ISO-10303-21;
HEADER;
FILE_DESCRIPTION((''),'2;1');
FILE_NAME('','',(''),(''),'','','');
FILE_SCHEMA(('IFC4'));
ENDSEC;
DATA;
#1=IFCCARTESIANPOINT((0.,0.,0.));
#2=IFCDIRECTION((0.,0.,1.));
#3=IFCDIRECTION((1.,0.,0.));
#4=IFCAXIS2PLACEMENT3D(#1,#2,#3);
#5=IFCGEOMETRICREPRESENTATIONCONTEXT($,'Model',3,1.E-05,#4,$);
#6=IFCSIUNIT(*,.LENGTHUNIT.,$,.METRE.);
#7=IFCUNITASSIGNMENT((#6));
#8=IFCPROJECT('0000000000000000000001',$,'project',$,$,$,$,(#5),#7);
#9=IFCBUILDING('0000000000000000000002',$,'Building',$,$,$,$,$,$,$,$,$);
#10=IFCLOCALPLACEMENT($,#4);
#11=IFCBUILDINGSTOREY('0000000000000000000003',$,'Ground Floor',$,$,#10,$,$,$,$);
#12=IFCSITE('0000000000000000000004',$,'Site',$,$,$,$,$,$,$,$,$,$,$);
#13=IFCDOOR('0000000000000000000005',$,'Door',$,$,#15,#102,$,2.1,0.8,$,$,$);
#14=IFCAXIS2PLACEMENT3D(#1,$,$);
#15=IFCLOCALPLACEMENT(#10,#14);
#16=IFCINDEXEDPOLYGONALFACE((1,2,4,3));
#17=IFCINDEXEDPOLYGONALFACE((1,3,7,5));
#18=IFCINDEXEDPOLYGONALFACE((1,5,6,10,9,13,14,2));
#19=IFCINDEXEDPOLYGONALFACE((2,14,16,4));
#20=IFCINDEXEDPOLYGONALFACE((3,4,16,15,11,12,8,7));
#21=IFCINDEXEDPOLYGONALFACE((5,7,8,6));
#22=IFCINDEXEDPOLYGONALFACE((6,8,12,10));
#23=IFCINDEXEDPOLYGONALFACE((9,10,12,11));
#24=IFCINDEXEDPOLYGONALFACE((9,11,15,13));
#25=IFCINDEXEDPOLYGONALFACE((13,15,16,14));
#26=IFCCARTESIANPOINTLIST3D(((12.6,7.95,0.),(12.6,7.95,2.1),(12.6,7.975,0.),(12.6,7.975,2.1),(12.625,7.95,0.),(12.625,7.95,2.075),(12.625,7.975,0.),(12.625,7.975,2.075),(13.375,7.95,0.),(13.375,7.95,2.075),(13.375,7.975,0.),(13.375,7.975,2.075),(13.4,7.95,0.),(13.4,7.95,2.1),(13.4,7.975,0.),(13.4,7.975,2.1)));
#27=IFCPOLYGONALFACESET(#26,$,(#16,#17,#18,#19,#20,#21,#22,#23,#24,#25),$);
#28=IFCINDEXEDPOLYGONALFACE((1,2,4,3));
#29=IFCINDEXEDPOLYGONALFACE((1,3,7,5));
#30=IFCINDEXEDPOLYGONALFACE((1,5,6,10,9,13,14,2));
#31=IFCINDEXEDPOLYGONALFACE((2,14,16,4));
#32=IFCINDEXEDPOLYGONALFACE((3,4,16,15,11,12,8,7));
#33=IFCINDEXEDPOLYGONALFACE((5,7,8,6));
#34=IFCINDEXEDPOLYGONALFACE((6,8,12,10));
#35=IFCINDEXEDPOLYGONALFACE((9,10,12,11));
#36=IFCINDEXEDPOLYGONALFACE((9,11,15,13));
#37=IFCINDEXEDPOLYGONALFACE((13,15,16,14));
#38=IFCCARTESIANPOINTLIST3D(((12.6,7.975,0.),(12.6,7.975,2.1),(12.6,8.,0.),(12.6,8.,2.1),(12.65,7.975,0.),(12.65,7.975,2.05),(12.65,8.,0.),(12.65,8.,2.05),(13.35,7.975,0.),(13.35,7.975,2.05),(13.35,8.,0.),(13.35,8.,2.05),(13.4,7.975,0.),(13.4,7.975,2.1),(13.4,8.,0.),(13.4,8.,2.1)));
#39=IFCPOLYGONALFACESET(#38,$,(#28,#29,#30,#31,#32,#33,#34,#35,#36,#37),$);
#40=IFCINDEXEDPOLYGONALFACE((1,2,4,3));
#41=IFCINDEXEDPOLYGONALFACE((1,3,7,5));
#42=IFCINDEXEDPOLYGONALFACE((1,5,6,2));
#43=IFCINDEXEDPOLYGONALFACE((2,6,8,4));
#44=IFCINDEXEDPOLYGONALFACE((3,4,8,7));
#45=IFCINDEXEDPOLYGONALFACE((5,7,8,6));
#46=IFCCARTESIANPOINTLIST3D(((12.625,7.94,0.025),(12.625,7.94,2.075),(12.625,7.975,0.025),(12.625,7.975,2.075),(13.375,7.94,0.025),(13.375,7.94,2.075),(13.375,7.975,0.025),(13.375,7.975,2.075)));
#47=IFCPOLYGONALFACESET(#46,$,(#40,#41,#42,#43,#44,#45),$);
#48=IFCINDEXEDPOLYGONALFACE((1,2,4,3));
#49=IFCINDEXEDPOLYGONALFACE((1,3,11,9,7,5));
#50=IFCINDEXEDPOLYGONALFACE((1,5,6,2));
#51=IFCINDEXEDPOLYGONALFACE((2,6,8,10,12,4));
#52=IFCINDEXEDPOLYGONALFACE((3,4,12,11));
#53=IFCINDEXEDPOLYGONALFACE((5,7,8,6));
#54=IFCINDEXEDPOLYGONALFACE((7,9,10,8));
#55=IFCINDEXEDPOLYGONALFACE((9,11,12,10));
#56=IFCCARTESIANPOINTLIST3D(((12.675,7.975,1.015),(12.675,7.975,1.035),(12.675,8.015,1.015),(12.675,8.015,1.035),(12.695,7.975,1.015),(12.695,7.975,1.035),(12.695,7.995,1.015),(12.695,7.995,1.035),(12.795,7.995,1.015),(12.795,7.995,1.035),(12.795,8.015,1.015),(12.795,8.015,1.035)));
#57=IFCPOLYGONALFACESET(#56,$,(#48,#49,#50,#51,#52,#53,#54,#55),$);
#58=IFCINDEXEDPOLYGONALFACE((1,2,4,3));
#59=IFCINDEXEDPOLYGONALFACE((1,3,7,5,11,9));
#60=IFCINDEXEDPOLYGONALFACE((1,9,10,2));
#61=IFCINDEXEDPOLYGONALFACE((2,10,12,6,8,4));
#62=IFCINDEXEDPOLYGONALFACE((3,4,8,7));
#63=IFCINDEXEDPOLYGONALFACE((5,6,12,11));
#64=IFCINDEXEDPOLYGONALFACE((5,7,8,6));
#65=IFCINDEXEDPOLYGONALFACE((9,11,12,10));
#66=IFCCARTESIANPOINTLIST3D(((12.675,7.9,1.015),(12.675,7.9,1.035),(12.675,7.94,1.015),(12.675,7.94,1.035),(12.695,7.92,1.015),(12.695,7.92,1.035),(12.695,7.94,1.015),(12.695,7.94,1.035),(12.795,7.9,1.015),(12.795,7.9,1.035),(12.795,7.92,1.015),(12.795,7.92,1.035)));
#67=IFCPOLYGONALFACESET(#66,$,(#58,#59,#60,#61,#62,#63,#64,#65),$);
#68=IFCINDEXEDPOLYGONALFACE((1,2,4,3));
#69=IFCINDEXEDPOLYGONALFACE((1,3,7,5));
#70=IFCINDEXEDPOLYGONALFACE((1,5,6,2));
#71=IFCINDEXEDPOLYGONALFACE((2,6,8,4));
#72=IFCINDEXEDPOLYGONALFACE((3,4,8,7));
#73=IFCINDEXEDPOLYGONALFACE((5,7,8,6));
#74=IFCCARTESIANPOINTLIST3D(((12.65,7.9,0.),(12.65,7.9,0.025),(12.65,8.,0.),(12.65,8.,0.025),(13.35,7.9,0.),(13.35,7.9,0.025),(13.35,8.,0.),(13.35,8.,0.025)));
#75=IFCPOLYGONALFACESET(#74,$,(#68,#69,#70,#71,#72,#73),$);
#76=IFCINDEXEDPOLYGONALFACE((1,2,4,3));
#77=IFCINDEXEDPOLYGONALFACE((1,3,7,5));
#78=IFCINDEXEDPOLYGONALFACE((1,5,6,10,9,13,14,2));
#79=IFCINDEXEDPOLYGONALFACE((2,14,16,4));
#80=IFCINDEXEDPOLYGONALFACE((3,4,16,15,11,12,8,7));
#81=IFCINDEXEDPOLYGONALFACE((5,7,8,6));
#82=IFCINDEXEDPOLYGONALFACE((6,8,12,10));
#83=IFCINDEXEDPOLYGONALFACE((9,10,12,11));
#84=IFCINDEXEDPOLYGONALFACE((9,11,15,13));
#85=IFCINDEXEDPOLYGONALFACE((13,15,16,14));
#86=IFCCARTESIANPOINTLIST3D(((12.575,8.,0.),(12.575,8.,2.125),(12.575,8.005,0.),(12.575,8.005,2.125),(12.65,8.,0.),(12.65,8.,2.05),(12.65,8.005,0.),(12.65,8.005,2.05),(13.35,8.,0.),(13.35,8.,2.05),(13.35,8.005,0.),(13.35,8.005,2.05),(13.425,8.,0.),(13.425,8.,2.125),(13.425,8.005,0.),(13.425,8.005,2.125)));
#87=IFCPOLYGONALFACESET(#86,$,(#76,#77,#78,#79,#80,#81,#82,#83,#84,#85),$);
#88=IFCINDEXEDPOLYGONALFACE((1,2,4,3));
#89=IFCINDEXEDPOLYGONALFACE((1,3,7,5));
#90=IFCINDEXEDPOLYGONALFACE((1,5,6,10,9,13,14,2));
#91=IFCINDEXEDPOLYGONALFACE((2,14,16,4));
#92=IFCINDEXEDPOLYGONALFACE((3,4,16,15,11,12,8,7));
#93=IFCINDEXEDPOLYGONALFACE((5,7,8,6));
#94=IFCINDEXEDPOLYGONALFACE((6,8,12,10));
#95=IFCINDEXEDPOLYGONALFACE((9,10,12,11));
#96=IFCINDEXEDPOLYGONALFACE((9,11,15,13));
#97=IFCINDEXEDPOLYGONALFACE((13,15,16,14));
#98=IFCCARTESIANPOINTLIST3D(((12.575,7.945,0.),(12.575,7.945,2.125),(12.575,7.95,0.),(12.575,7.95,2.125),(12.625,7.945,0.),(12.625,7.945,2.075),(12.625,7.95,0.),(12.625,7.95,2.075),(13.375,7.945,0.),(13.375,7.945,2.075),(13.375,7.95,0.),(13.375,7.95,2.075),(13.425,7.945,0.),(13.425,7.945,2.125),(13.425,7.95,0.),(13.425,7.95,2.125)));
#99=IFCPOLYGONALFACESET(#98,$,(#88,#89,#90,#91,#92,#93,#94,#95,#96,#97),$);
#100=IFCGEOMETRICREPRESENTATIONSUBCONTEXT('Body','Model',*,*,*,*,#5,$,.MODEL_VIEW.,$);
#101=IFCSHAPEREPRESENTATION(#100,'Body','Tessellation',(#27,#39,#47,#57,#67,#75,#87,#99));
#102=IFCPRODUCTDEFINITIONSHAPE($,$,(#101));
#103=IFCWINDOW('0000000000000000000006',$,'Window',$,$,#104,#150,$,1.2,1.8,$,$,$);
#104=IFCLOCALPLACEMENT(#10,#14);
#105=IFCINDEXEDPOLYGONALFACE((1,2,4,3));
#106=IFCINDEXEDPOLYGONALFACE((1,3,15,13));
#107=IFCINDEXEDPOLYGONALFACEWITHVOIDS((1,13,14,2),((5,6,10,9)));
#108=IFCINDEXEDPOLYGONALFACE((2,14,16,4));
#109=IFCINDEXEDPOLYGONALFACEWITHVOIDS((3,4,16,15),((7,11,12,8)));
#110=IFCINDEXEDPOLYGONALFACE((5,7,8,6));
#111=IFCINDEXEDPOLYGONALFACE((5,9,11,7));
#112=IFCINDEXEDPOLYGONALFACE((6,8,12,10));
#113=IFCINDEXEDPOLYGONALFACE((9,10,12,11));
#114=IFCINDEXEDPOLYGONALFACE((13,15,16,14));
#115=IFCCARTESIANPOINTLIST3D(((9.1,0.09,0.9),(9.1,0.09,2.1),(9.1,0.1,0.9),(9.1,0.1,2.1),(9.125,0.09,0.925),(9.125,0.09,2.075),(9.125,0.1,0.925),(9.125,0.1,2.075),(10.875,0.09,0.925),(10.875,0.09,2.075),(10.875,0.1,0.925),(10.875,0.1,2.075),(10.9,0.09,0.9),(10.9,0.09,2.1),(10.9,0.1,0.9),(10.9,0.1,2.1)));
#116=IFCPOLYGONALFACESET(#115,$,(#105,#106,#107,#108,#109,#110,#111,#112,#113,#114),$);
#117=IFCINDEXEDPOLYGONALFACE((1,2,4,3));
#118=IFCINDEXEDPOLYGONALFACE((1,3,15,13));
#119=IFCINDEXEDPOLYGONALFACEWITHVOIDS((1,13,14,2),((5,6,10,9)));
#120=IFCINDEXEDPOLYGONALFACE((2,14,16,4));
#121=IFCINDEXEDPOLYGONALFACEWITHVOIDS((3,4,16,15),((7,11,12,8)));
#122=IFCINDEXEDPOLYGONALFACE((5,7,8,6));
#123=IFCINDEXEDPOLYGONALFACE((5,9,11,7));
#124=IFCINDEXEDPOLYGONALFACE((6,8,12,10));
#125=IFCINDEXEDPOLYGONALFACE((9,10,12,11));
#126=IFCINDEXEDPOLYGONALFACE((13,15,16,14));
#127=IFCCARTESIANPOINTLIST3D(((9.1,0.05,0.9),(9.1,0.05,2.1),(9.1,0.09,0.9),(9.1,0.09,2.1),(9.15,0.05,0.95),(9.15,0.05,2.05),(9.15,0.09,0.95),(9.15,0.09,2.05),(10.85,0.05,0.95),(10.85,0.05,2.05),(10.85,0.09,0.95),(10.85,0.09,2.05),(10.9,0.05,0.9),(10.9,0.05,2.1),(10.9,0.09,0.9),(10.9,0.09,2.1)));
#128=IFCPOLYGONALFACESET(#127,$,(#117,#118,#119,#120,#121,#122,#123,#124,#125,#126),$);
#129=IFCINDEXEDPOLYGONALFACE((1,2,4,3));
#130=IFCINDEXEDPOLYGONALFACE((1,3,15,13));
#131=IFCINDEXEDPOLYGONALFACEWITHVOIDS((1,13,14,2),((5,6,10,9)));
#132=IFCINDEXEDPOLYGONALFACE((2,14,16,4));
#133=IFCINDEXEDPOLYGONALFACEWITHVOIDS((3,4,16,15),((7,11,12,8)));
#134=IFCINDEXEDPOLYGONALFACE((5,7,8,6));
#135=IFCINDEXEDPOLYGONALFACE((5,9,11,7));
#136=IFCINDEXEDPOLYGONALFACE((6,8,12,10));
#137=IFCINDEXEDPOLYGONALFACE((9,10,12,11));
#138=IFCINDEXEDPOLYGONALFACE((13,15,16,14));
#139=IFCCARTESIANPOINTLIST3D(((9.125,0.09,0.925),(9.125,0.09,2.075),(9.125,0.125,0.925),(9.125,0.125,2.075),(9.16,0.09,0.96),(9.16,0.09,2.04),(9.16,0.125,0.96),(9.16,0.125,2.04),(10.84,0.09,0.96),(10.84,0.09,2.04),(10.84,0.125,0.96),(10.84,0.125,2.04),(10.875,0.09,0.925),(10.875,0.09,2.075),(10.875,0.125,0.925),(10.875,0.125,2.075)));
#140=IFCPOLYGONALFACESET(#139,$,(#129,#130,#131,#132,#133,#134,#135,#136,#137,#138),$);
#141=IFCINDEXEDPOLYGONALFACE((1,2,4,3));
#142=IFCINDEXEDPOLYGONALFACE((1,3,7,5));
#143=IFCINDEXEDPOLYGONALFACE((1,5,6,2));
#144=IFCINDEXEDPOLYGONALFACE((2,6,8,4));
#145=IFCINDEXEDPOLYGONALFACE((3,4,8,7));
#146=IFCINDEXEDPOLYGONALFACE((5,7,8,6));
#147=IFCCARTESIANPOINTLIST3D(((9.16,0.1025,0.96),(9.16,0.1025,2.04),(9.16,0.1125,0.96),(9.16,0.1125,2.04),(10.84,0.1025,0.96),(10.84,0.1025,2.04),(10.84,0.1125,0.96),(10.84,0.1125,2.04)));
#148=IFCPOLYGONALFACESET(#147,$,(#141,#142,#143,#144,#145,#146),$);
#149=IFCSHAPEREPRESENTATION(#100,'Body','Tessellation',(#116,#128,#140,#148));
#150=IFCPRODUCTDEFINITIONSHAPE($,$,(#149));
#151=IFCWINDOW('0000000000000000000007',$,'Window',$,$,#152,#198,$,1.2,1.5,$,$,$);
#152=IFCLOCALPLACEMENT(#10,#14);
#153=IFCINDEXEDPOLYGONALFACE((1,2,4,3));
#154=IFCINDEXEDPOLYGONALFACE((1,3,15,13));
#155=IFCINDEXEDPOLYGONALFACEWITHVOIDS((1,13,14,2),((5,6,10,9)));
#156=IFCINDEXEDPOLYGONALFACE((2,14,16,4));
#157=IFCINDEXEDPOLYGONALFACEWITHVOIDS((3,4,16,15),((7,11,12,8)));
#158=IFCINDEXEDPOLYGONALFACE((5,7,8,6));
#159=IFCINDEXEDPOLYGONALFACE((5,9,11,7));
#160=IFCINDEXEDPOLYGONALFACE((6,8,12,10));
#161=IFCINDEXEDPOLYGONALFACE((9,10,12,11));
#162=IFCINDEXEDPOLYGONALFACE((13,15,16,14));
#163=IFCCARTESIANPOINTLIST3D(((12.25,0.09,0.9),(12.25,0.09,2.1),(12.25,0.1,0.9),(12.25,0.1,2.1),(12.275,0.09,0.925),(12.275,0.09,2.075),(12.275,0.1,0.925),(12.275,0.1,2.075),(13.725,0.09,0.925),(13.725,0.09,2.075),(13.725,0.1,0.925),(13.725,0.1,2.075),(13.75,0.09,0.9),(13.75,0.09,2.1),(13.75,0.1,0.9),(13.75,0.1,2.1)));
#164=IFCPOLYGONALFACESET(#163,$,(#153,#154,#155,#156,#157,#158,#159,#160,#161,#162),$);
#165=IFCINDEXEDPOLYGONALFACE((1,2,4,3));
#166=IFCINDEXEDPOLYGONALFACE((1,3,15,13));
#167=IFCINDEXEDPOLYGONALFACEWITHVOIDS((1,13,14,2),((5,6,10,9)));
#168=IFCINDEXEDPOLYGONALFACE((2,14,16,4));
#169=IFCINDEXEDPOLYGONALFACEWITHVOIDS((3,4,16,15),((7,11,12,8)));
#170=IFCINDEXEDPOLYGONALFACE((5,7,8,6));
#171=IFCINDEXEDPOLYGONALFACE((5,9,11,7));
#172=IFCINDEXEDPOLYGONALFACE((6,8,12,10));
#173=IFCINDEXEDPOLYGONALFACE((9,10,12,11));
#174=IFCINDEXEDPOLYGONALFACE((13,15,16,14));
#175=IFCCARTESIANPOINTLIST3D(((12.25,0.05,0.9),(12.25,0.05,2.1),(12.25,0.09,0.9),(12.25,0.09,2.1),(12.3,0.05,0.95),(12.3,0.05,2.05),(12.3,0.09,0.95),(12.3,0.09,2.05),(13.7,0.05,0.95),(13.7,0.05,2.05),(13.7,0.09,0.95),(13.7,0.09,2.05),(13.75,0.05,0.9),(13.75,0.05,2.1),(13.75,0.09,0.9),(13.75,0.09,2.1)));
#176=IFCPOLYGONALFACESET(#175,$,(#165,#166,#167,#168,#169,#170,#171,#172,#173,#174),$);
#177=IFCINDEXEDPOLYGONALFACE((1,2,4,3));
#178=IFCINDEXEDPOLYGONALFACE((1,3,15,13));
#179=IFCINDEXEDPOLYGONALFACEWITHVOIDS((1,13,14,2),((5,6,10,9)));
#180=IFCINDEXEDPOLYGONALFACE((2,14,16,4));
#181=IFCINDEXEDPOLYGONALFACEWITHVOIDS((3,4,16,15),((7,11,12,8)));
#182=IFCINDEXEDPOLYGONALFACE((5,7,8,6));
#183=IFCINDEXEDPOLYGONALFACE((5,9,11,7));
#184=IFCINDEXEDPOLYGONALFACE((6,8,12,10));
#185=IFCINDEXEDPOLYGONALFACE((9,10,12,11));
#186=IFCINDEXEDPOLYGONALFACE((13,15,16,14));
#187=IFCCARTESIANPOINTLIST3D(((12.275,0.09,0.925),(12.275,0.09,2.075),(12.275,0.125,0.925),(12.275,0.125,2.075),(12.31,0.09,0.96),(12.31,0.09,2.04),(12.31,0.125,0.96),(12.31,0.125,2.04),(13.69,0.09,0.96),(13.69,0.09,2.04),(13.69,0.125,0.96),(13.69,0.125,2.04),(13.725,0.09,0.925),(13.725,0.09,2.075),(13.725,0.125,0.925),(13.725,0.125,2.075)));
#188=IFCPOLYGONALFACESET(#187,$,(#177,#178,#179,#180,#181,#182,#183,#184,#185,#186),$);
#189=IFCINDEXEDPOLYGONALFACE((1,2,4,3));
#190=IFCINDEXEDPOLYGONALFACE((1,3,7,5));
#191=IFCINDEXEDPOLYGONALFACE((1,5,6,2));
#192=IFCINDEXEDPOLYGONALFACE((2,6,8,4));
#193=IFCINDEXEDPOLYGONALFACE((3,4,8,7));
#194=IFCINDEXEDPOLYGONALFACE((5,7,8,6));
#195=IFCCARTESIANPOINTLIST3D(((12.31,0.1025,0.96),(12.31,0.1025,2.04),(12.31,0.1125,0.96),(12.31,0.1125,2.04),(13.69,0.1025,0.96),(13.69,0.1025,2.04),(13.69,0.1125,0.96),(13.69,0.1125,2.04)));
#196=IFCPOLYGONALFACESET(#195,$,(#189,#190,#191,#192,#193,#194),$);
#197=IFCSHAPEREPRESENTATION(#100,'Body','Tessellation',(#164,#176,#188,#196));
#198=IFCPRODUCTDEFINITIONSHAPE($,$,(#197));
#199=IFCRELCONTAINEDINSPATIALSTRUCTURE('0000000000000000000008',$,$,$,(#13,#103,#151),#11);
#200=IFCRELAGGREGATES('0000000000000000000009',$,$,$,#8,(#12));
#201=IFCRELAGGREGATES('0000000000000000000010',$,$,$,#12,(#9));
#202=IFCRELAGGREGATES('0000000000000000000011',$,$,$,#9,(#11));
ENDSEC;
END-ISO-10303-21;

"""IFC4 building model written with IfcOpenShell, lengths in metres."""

from ifc_helpers import new_model, si_unit, frame, origin_with_axes, place, context, subcontext, project, spatial, line, indexed_curve, outline, extrude, element, save


model = new_model("IFC4")

# Units and contexts
model_context = context("Model", 3, precision=1e-05, world=origin_with_axes())
body_context = subcontext(model_context, "Body", "Model", "MODEL_VIEW")
ifc_project = project(units=[si_unit("LENGTHUNIT", "METRE")], contexts=[model_context])

# Site, building, storey
site = spatial("IfcSite", under=ifc_project, Name="Site")
building = spatial("IfcBuilding", under=site, Name="Building")
storey_placement = place(None, origin_with_axes())
storey = spatial("IfcBuildingStorey", under=building, at=storey_placement, Name="Ground Floor")

# Door
door_1_placement = place(storey_placement, frame((13.4, 8.0, 0.0), z_axis=(0.0, 0.0, 1.0), x_axis=(-1.0, 0.0, 0.0)))
element("IfcDoor", 1, at=door_1_placement, inside=storey, Name="Door", OverallHeight=2.1, OverallWidth=0.8, context=body_context, shape_type="SweptSolid", body=[
    extrude(outline(indexed_curve([(0.0, 0.0), (0.0, 2.1), (0.8, 2.1), (0.8, 0.0), (0.775, 0.0), (0.775, 2.075), (0.025, 2.075), (0.025, 0.0)], segments=[line(1, 2, 3, 4, 5, 6, 7, 8, 1)])), frame((0.0, 0.025, 0.0), z_axis=(0.0, -1.0, 0.0), x_axis=(1.0, 0.0, 0.0)), (0.0, 0.0, -1.0), 0.025),
    extrude(outline(indexed_curve([(0.0, 0.0), (0.0, 2.1), (0.8, 2.1), (0.8, 0.0), (0.75, 0.0), (0.75, 2.05), (0.05, 2.05), (0.05, 0.0)], segments=[line(1, 2, 3, 4, 5, 6, 7, 8, 1)])), frame((0.0, 0.0, 0.0), z_axis=(0.0, -1.0, 0.0), x_axis=(1.0, 0.0, 0.0)), (0.0, 0.0, -1.0), 0.025),
    extrude(outline(indexed_curve([(0.0, 0.0), (0.75, 0.0), (0.75, 0.035), (0.0, 0.035)], segments=[line(1, 2, 3, 4, 1)])), frame((0.025, 0.025, 0.025), z_axis=(0.0, 0.0, 1.0), x_axis=(1.0, 0.0, 0.0)), (0.0, 0.0, 1.0), 2.05),
    extrude(outline(indexed_curve([(0.0, 0.0), (0.0, -0.04), (-0.12, -0.04), (-0.12, -0.02), (-0.02, -0.02), (-0.02, 0.0)], segments=[line(1, 2, 3, 4, 5, 6, 1)])), frame((0.725, 0.025, 1.015), z_axis=(0.0, 0.0, 1.0), x_axis=(1.0, 0.0, 0.0)), (0.0, 0.0, 1.0), 0.02),
    extrude(outline(indexed_curve([(0.0, 0.0), (0.0, 0.04), (-0.12, 0.04), (-0.12, 0.02), (-0.02, 0.02), (-0.02, 0.0)], segments=[line(1, 2, 3, 4, 5, 6, 1)])), frame((0.725, 0.06, 1.015), z_axis=(0.0, 0.0, 1.0), x_axis=(1.0, 0.0, 0.0)), (0.0, 0.0, 1.0), 0.02),
    extrude(outline(indexed_curve([(0.0, 0.0), (0.7, 0.0), (0.7, 0.1), (0.0, 0.1)], segments=[line(1, 2, 3, 4, 1)])), frame((0.05, 0.0, 0.0), z_axis=(0.0, 0.0, 1.0), x_axis=(1.0, 0.0, 0.0)), (0.0, 0.0, 1.0), 0.025),
    extrude(outline(indexed_curve([(0.0, 0.0), (0.0, 2.125), (0.85, 2.125), (0.85, 0.0), (0.775, 0.0), (0.775, 2.05), (0.075, 2.05), (0.075, 0.0)], segments=[line(1, 2, 3, 4, 5, 6, 7, 8, 1)])), frame((-0.025, -0.005, 0.0), z_axis=(0.0, -1.0, 0.0), x_axis=(1.0, 0.0, 0.0)), (0.0, 0.0, -1.0), 0.005),
    extrude(outline(indexed_curve([(0.0, 0.0), (0.0, 2.125), (0.85, 2.125), (0.85, 0.0), (0.8, 0.0), (0.8, 2.075), (0.05, 2.075), (0.05, 0.0)], segments=[line(1, 2, 3, 4, 5, 6, 7, 8, 1)])), frame((-0.025, 0.05, 0.0), z_axis=(0.0, -1.0, 0.0), x_axis=(1.0, 0.0, 0.0)), (0.0, 0.0, -1.0), 0.005),
])

# Windows
window_1_placement = place(storey_placement, frame((9.1, 0.0, 0.9), z_axis=(0.0, 0.0, 1.0), x_axis=(1.0, 0.0, 0.0)))
element("IfcWindow", 2, at=window_1_placement, inside=storey, Name="Window", OverallHeight=1.2, OverallWidth=1.8, context=body_context, shape_type="SweptSolid", body=[
    extrude(outline(indexed_curve([(0.0, 0.0), (1.8, 0.0), (1.8, 1.2), (0.0, 1.2)], segments=[line(1, 2, 3, 4, 1)]), holes=[indexed_curve([(0.025, 0.025), (1.775, 0.025), (1.775, 1.175), (0.025, 1.175)], segments=[line(1, 2, 3, 4, 1)])]), frame((0.0, 0.09, 0.0), z_axis=(0.0, -1.0, 0.0), x_axis=(1.0, 0.0, 0.0)), (0.0, 0.0, -1.0), 0.01),
    extrude(outline(indexed_curve([(0.0, 0.0), (1.8, 0.0), (1.8, 1.2), (0.0, 1.2)], segments=[line(1, 2, 3, 4, 1)]), holes=[indexed_curve([(0.05, 0.05), (1.75, 0.05), (1.75, 1.15), (0.05, 1.15)], segments=[line(1, 2, 3, 4, 1)])]), frame((0.0, 0.05, 0.0), z_axis=(0.0, -1.0, 0.0), x_axis=(1.0, 0.0, 0.0)), (0.0, 0.0, -1.0), 0.04),
    extrude(outline(indexed_curve([(0.0, 0.0), (1.75, 0.0), (1.75, 1.15), (0.0, 1.15)], segments=[line(1, 2, 3, 4, 1)]), holes=[indexed_curve([(0.035, 0.035), (1.715, 0.035), (1.715, 1.115), (0.035, 1.115)], segments=[line(1, 2, 3, 4, 1)])]), frame((0.025, 0.09, 0.025), z_axis=(0.0, -1.0, 0.0), x_axis=(1.0, 0.0, 0.0)), (0.0, 0.0, -1.0), 0.035),
    extrude(outline(indexed_curve([(0.035, 0.035), (1.715, 0.035), (1.715, 1.115), (0.035, 1.115)], segments=[line(1, 2, 3, 4, 1)])), frame((0.025, 0.1025, 0.025), z_axis=(0.0, -1.0, 0.0), x_axis=(1.0, 0.0, 0.0)), (0.0, 0.0, -1.0), 0.01),
])
window_2_placement = place(storey_placement, frame((12.25, 0.0, 0.9), z_axis=(0.0, 0.0, 1.0), x_axis=(1.0, 0.0, 0.0)))
element("IfcWindow", 3, at=window_2_placement, inside=storey, Name="Window", OverallHeight=1.2, OverallWidth=1.5, context=body_context, shape_type="SweptSolid", body=[
    extrude(outline(indexed_curve([(0.0, 0.0), (1.5, 0.0), (1.5, 1.2), (0.0, 1.2)], segments=[line(1, 2, 3, 4, 1)]), holes=[indexed_curve([(0.025, 0.025), (1.475, 0.025), (1.475, 1.175), (0.025, 1.175)], segments=[line(1, 2, 3, 4, 1)])]), frame((0.0, 0.09, 0.0), z_axis=(0.0, -1.0, 0.0), x_axis=(1.0, 0.0, 0.0)), (0.0, 0.0, -1.0), 0.01),
    extrude(outline(indexed_curve([(0.0, 0.0), (1.5, 0.0), (1.5, 1.2), (0.0, 1.2)], segments=[line(1, 2, 3, 4, 1)]), holes=[indexed_curve([(0.05, 0.05), (1.45, 0.05), (1.45, 1.15), (0.05, 1.15)], segments=[line(1, 2, 3, 4, 1)])]), frame((0.0, 0.05, 0.0), z_axis=(0.0, -1.0, 0.0), x_axis=(1.0, 0.0, 0.0)), (0.0, 0.0, -1.0), 0.04),
    extrude(outline(indexed_curve([(0.0, 0.0), (1.45, 0.0), (1.45, 1.15), (0.0, 1.15)], segments=[line(1, 2, 3, 4, 1)]), holes=[indexed_curve([(0.035, 0.035), (1.415, 0.035), (1.415, 1.115), (0.035, 1.115)], segments=[line(1, 2, 3, 4, 1)])]), frame((0.025, 0.09, 0.025), z_axis=(0.0, -1.0, 0.0), x_axis=(1.0, 0.0, 0.0)), (0.0, 0.0, -1.0), 0.035),
    extrude(outline(indexed_curve([(0.035, 0.035), (1.415, 0.035), (1.415, 1.115), (0.035, 1.115)], segments=[line(1, 2, 3, 4, 1)])), frame((0.025, 0.1025, 0.025), z_axis=(0.0, -1.0, 0.0), x_axis=(1.0, 0.0, 0.0)), (0.0, 0.0, -1.0), 0.01),
])

save(model, "model.ifc")
